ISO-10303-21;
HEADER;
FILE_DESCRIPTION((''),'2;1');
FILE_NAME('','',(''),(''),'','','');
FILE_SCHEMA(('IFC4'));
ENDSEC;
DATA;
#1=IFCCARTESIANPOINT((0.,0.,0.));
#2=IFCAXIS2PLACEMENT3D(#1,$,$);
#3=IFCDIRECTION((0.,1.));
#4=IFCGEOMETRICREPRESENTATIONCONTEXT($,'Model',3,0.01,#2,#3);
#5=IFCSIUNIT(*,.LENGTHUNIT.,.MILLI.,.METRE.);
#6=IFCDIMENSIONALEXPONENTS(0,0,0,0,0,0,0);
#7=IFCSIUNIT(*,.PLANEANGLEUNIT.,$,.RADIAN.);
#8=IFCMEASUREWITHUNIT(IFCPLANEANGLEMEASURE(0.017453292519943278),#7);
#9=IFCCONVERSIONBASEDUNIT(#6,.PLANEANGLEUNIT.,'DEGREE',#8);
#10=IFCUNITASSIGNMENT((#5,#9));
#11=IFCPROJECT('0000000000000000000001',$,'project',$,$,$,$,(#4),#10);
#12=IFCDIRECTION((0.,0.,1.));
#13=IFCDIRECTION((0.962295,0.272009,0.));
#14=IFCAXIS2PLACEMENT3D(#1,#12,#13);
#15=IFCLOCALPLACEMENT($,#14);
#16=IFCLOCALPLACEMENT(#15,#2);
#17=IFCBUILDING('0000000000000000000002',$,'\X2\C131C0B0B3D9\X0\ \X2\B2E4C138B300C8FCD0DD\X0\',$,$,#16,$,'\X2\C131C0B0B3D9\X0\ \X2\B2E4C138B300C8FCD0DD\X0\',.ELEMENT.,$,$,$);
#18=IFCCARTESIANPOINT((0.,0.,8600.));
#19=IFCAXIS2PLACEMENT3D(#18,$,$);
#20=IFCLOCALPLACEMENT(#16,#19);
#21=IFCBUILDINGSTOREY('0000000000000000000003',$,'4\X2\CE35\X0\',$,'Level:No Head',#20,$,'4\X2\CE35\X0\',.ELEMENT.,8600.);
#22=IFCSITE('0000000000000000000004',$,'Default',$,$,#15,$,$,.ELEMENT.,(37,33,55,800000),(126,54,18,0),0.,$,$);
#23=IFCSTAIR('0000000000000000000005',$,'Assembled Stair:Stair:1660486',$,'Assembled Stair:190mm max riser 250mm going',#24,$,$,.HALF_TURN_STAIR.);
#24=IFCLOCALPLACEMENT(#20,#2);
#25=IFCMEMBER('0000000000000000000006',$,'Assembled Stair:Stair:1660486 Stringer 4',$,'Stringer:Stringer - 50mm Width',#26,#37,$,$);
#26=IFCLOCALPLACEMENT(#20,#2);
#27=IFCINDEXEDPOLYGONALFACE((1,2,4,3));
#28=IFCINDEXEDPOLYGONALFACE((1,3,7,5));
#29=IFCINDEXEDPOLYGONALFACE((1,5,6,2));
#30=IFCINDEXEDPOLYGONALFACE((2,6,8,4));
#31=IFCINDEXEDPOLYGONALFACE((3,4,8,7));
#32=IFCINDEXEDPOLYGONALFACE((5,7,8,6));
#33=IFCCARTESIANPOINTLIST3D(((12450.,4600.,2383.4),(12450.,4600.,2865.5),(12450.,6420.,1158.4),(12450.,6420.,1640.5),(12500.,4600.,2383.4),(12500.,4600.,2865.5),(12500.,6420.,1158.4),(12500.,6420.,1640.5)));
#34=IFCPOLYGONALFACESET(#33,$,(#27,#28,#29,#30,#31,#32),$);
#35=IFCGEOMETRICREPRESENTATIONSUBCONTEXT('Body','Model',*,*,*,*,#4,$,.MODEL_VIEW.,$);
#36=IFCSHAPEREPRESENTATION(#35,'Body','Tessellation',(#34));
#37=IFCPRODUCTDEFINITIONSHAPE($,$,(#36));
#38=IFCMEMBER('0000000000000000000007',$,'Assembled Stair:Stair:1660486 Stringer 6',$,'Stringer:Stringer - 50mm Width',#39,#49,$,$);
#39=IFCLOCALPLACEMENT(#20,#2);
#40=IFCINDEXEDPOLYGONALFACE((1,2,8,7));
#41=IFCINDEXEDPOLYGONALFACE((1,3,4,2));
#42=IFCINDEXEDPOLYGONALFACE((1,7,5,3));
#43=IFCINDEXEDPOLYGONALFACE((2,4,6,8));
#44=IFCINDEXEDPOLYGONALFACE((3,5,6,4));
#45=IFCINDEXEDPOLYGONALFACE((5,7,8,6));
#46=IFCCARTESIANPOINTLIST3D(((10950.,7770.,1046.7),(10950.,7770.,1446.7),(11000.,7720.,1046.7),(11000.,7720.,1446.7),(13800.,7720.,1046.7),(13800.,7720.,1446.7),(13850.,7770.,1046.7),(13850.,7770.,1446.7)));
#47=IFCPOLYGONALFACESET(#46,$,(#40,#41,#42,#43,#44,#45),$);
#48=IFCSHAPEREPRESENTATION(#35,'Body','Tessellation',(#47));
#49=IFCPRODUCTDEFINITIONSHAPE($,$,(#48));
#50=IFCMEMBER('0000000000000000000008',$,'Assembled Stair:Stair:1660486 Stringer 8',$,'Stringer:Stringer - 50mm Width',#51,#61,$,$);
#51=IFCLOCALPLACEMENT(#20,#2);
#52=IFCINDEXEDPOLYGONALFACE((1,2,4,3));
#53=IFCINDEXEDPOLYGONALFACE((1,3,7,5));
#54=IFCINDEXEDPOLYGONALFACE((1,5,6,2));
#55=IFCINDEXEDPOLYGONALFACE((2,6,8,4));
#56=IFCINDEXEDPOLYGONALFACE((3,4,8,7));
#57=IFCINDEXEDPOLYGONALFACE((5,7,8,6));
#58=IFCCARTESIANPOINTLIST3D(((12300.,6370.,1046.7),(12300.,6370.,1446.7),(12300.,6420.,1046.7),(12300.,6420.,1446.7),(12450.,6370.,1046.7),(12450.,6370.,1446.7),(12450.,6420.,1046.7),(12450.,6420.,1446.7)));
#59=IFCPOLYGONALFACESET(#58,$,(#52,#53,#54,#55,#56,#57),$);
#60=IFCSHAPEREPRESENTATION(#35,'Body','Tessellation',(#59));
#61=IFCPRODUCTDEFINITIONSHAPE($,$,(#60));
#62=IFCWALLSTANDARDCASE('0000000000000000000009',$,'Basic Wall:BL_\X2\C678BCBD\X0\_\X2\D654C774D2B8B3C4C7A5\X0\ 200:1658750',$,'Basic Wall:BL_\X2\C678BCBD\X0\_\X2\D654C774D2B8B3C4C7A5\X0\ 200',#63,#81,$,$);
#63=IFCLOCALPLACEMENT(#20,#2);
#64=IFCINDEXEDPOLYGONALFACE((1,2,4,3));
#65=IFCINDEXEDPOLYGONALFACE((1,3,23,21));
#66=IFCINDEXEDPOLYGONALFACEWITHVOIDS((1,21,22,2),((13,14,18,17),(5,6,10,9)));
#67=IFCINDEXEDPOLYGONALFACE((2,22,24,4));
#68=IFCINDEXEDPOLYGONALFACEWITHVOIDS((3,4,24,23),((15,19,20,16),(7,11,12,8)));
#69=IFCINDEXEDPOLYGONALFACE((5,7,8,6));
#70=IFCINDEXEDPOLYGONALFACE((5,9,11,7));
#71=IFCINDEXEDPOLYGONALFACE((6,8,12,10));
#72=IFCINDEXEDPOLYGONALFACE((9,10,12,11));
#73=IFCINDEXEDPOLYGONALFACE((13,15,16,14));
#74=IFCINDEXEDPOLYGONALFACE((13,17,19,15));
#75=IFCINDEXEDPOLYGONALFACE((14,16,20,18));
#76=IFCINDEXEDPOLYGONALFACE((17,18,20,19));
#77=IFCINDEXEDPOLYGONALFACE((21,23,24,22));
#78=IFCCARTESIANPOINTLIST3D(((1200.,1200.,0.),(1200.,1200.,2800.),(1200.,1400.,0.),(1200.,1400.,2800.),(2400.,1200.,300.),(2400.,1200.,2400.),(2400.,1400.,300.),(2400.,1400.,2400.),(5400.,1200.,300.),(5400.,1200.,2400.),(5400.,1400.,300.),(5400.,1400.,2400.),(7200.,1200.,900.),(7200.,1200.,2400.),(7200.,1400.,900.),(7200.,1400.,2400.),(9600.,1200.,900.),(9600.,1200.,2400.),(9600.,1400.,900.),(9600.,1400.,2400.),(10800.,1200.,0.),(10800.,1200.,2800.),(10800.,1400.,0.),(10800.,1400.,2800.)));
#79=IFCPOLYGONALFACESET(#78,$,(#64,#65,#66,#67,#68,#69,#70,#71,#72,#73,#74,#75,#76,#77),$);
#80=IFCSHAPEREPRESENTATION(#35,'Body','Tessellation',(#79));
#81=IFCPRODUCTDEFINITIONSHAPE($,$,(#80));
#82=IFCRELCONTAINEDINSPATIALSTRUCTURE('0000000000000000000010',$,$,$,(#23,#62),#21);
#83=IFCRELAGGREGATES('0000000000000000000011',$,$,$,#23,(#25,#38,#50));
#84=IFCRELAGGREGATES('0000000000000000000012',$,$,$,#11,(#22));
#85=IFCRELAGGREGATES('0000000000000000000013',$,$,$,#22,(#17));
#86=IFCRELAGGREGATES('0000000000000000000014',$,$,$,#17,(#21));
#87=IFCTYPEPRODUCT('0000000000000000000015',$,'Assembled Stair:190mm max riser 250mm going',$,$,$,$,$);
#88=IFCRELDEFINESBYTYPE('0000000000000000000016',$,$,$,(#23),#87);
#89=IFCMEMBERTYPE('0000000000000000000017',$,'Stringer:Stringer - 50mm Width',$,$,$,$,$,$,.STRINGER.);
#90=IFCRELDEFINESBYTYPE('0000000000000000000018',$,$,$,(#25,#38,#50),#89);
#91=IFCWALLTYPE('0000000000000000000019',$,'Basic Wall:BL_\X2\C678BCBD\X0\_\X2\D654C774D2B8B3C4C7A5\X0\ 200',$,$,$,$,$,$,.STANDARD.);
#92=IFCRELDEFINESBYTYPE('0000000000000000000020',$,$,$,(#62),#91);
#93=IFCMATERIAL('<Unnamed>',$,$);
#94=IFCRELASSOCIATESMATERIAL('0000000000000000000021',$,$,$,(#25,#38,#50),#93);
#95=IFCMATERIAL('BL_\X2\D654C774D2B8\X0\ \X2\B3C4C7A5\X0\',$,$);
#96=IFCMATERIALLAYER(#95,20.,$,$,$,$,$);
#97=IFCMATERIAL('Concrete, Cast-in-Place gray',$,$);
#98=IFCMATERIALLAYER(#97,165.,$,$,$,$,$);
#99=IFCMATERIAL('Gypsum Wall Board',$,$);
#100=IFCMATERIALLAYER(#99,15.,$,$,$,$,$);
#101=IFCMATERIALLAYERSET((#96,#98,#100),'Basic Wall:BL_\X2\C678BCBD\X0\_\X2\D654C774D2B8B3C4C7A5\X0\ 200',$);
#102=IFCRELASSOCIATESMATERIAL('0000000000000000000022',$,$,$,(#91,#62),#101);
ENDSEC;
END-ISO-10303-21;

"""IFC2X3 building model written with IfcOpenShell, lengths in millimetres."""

from ifc_helpers import new_model, entity, si_unit, converted_unit, direction, frame, frame_2d, origin, origin_2d_with_axis, place, context, subcontext, project, spatial, polyline, rectangle, outline, extrude, material, layer, layer_set, layer_usage, type_object, element, aggregate, save


model = new_model("IFC2X3")

# Units and contexts
model_context = context("Model", 3, precision=0.01, world=origin(), true_north=direction((0.0, 1.0)))
body_context = subcontext(model_context, "Body", "Model", "MODEL_VIEW")
ifc_project = project(units=[si_unit("LENGTHUNIT", "METRE", prefix="MILLI"), converted_unit("PLANEANGLEUNIT", "DEGREE", entity("IfcPlaneAngleMeasure", 0.017453292519943278), si_unit("PLANEANGLEUNIT", "RADIAN"), dimensions=[0, 0, 0, 0, 0, 0, 0])], contexts=[model_context])

# Site, building, storey
site_placement = place(None, frame((0.0, 0.0, 0.0), z_axis=(0.0, 0.0, 1.0), x_axis=(0.962295, 0.272009, 0.0)))
site = spatial("IfcSite", under=ifc_project, at=site_placement, Name="Default", CompositionType="ELEMENT", RefLatitude=(37, 33, 55, 800000), RefLongitude=(126, 54, 18, 0), RefElevation=0.0)
building_placement = place(site_placement, origin())
building = spatial("IfcBuilding", under=site, at=building_placement, Name="성산동 다세대주택", LongName="성산동 다세대주택", CompositionType="ELEMENT")
storey_placement = place(building_placement, frame((0.0, 0.0, 8600.0)))
storey = spatial("IfcBuildingStorey", under=building, at=storey_placement, Name="4층", ObjectType="Level:No Head", LongName="4층", CompositionType="ELEMENT", Elevation=8600.0)

# Stair, members
type_product = type_object("IfcTypeProduct", Name="Assembled Stair:190mm max riser 250mm going")
stair_placement = place(storey_placement, origin())
stair = element("IfcStair", 1, at=stair_placement, inside=storey, type_object=type_product, Name="Assembled Stair:Stair:1660486", ObjectType="Assembled Stair:190mm max riser 250mm going", ShapeType="HALF_TURN_STAIR")
ifc_material_1 = material(Name="<Unnamed>")
member_type = type_object("IfcMemberType", Name="Stringer:Stringer - 50mm Width", PredefinedType="STRINGER")
member_1_placement = place(stair_placement, origin())
member_1 = element("IfcMember", 2, at=member_1_placement, type_object=member_type, material=ifc_material_1, Name="Assembled Stair:Stair:1660486 Stringer 4", ObjectType="Stringer:Stringer - 50mm Width", context=body_context, shape_type="SweptSolid", body=[
    extrude(outline(polyline([(-962.3, -200.0), (1231.5, -200.0), (962.3, 200.0), (-1231.5, 200.0), (-962.3, -200.0)])), frame((12450.0, 5510.0, 2011.9), z_axis=(1.0, 0.0, 0.0), x_axis=(0.0, -0.829588, 0.558376)), (0.0, 0.0, 1.0), 50.0),
])
member_2_placement = place(stair_placement, origin())
member_2 = element("IfcMember", 3, at=member_2_placement, type_object=member_type, material=ifc_material_1, Name="Assembled Stair:Stair:1660486 Stringer 6", ObjectType="Stringer:Stringer - 50mm Width", context=body_context, shape_type="SweptSolid", body=[
    extrude(outline(polyline([(-1450.0, -25.0), (1450.0, -25.0), (1400.0, 25.0), (-1400.0, 25.0), (-1450.0, -25.0)])), frame((12400.0, 7745.0, 1046.7), z_axis=(0.0, 0.0, 1.0), x_axis=(-1.0, 0.0, 0.0)), (0.0, 0.0, 1.0), 400.0),
])
member_3_placement = place(stair_placement, origin())
member_3 = element("IfcMember", 4, at=member_3_placement, type_object=member_type, material=ifc_material_1, Name="Assembled Stair:Stair:1660486 Stringer 8", ObjectType="Stringer:Stringer - 50mm Width", context=body_context, shape_type="SweptSolid", body=[
    extrude(rectangle(XDim=150.0, YDim=50.0, at=origin_2d_with_axis()), frame((12375.0, 6395.0, 1046.7)), (0.0, 0.0, 1.0), 400.0),
])

# Shared definitions
ifc_material_2 = material(Name="Concrete, Cast-in-Place gray")

# Wall, openings
ifc_material_3 = material(Name="BL_화이트 도장")
ifc_layer_1 = layer(ifc_material_3, 20.0)
ifc_layer_2 = layer(ifc_material_2, 165.0)
ifc_material_4 = material(Name="Gypsum Wall Board")
ifc_layer_3 = layer(ifc_material_4, 15.0)
ifc_layer_set_1 = layer_set([ifc_layer_1, ifc_layer_2, ifc_layer_3], Name="Basic Wall:BL_외벽_화이트도장 200")
ifc_layer_usage_1 = layer_usage(ifc_layer_set_1, "AXIS2", "POSITIVE", -100.0)
wall_type = type_object("IfcWallType", Name="Basic Wall:BL_외벽_화이트도장 200", PredefinedType="STANDARD", material=ifc_layer_set_1)
wall_placement = place(storey_placement, frame((1200.0, 1300.0, 0.0)))
wall = element("IfcWallStandardCase", 5, at=wall_placement, inside=storey, type_object=wall_type, material=ifc_layer_usage_1, Name="Basic Wall:BL_외벽_화이트도장 200:1658750", ObjectType="Basic Wall:BL_외벽_화이트도장 200", context=body_context, shape_type="SweptSolid", body=[
    extrude(rectangle(XDim=9600.0, YDim=200.0, at=frame_2d((4800.0, 0.0), x_axis=(-1.0, 0.0))), origin(), (0.0, 0.0, 1.0), 2800.0),
])
opening_1_placement = place(wall_placement, frame((1200.0, -100.0, 300.0)))
element("IfcOpeningElement", 6, at=opening_1_placement, cuts=wall, ObjectType="Opening", context=body_context, shape_type="SweptSolid", body=[
    extrude(rectangle(XDim=2100.0, YDim=3000.0, at=frame_2d((1050.0, 1500.0), x_axis=(-1.0, 0.0))), frame((0.0, 0.0, 0.0), z_axis=(0.0, 1.0, 0.0), x_axis=(0.0, 0.0, 1.0)), (0.0, 0.0, 1.0), 200.0),
])
opening_2_placement = place(wall_placement, frame((6000.0, -100.0, 900.0)))
element("IfcOpeningElement", 7, at=opening_2_placement, cuts=wall, ObjectType="Opening", context=body_context, shape_type="SweptSolid", body=[
    extrude(rectangle(XDim=1500.0, YDim=2400.0, at=frame_2d((750.0, 1200.0), x_axis=(-1.0, 0.0))), frame((0.0, 0.0, 0.0), z_axis=(0.0, 1.0, 0.0), x_axis=(0.0, 0.0, 1.0)), (0.0, 0.0, 1.0), 200.0),
])

aggregate(stair, [member_1, member_2, member_3])

save(model, "model.ifc")
